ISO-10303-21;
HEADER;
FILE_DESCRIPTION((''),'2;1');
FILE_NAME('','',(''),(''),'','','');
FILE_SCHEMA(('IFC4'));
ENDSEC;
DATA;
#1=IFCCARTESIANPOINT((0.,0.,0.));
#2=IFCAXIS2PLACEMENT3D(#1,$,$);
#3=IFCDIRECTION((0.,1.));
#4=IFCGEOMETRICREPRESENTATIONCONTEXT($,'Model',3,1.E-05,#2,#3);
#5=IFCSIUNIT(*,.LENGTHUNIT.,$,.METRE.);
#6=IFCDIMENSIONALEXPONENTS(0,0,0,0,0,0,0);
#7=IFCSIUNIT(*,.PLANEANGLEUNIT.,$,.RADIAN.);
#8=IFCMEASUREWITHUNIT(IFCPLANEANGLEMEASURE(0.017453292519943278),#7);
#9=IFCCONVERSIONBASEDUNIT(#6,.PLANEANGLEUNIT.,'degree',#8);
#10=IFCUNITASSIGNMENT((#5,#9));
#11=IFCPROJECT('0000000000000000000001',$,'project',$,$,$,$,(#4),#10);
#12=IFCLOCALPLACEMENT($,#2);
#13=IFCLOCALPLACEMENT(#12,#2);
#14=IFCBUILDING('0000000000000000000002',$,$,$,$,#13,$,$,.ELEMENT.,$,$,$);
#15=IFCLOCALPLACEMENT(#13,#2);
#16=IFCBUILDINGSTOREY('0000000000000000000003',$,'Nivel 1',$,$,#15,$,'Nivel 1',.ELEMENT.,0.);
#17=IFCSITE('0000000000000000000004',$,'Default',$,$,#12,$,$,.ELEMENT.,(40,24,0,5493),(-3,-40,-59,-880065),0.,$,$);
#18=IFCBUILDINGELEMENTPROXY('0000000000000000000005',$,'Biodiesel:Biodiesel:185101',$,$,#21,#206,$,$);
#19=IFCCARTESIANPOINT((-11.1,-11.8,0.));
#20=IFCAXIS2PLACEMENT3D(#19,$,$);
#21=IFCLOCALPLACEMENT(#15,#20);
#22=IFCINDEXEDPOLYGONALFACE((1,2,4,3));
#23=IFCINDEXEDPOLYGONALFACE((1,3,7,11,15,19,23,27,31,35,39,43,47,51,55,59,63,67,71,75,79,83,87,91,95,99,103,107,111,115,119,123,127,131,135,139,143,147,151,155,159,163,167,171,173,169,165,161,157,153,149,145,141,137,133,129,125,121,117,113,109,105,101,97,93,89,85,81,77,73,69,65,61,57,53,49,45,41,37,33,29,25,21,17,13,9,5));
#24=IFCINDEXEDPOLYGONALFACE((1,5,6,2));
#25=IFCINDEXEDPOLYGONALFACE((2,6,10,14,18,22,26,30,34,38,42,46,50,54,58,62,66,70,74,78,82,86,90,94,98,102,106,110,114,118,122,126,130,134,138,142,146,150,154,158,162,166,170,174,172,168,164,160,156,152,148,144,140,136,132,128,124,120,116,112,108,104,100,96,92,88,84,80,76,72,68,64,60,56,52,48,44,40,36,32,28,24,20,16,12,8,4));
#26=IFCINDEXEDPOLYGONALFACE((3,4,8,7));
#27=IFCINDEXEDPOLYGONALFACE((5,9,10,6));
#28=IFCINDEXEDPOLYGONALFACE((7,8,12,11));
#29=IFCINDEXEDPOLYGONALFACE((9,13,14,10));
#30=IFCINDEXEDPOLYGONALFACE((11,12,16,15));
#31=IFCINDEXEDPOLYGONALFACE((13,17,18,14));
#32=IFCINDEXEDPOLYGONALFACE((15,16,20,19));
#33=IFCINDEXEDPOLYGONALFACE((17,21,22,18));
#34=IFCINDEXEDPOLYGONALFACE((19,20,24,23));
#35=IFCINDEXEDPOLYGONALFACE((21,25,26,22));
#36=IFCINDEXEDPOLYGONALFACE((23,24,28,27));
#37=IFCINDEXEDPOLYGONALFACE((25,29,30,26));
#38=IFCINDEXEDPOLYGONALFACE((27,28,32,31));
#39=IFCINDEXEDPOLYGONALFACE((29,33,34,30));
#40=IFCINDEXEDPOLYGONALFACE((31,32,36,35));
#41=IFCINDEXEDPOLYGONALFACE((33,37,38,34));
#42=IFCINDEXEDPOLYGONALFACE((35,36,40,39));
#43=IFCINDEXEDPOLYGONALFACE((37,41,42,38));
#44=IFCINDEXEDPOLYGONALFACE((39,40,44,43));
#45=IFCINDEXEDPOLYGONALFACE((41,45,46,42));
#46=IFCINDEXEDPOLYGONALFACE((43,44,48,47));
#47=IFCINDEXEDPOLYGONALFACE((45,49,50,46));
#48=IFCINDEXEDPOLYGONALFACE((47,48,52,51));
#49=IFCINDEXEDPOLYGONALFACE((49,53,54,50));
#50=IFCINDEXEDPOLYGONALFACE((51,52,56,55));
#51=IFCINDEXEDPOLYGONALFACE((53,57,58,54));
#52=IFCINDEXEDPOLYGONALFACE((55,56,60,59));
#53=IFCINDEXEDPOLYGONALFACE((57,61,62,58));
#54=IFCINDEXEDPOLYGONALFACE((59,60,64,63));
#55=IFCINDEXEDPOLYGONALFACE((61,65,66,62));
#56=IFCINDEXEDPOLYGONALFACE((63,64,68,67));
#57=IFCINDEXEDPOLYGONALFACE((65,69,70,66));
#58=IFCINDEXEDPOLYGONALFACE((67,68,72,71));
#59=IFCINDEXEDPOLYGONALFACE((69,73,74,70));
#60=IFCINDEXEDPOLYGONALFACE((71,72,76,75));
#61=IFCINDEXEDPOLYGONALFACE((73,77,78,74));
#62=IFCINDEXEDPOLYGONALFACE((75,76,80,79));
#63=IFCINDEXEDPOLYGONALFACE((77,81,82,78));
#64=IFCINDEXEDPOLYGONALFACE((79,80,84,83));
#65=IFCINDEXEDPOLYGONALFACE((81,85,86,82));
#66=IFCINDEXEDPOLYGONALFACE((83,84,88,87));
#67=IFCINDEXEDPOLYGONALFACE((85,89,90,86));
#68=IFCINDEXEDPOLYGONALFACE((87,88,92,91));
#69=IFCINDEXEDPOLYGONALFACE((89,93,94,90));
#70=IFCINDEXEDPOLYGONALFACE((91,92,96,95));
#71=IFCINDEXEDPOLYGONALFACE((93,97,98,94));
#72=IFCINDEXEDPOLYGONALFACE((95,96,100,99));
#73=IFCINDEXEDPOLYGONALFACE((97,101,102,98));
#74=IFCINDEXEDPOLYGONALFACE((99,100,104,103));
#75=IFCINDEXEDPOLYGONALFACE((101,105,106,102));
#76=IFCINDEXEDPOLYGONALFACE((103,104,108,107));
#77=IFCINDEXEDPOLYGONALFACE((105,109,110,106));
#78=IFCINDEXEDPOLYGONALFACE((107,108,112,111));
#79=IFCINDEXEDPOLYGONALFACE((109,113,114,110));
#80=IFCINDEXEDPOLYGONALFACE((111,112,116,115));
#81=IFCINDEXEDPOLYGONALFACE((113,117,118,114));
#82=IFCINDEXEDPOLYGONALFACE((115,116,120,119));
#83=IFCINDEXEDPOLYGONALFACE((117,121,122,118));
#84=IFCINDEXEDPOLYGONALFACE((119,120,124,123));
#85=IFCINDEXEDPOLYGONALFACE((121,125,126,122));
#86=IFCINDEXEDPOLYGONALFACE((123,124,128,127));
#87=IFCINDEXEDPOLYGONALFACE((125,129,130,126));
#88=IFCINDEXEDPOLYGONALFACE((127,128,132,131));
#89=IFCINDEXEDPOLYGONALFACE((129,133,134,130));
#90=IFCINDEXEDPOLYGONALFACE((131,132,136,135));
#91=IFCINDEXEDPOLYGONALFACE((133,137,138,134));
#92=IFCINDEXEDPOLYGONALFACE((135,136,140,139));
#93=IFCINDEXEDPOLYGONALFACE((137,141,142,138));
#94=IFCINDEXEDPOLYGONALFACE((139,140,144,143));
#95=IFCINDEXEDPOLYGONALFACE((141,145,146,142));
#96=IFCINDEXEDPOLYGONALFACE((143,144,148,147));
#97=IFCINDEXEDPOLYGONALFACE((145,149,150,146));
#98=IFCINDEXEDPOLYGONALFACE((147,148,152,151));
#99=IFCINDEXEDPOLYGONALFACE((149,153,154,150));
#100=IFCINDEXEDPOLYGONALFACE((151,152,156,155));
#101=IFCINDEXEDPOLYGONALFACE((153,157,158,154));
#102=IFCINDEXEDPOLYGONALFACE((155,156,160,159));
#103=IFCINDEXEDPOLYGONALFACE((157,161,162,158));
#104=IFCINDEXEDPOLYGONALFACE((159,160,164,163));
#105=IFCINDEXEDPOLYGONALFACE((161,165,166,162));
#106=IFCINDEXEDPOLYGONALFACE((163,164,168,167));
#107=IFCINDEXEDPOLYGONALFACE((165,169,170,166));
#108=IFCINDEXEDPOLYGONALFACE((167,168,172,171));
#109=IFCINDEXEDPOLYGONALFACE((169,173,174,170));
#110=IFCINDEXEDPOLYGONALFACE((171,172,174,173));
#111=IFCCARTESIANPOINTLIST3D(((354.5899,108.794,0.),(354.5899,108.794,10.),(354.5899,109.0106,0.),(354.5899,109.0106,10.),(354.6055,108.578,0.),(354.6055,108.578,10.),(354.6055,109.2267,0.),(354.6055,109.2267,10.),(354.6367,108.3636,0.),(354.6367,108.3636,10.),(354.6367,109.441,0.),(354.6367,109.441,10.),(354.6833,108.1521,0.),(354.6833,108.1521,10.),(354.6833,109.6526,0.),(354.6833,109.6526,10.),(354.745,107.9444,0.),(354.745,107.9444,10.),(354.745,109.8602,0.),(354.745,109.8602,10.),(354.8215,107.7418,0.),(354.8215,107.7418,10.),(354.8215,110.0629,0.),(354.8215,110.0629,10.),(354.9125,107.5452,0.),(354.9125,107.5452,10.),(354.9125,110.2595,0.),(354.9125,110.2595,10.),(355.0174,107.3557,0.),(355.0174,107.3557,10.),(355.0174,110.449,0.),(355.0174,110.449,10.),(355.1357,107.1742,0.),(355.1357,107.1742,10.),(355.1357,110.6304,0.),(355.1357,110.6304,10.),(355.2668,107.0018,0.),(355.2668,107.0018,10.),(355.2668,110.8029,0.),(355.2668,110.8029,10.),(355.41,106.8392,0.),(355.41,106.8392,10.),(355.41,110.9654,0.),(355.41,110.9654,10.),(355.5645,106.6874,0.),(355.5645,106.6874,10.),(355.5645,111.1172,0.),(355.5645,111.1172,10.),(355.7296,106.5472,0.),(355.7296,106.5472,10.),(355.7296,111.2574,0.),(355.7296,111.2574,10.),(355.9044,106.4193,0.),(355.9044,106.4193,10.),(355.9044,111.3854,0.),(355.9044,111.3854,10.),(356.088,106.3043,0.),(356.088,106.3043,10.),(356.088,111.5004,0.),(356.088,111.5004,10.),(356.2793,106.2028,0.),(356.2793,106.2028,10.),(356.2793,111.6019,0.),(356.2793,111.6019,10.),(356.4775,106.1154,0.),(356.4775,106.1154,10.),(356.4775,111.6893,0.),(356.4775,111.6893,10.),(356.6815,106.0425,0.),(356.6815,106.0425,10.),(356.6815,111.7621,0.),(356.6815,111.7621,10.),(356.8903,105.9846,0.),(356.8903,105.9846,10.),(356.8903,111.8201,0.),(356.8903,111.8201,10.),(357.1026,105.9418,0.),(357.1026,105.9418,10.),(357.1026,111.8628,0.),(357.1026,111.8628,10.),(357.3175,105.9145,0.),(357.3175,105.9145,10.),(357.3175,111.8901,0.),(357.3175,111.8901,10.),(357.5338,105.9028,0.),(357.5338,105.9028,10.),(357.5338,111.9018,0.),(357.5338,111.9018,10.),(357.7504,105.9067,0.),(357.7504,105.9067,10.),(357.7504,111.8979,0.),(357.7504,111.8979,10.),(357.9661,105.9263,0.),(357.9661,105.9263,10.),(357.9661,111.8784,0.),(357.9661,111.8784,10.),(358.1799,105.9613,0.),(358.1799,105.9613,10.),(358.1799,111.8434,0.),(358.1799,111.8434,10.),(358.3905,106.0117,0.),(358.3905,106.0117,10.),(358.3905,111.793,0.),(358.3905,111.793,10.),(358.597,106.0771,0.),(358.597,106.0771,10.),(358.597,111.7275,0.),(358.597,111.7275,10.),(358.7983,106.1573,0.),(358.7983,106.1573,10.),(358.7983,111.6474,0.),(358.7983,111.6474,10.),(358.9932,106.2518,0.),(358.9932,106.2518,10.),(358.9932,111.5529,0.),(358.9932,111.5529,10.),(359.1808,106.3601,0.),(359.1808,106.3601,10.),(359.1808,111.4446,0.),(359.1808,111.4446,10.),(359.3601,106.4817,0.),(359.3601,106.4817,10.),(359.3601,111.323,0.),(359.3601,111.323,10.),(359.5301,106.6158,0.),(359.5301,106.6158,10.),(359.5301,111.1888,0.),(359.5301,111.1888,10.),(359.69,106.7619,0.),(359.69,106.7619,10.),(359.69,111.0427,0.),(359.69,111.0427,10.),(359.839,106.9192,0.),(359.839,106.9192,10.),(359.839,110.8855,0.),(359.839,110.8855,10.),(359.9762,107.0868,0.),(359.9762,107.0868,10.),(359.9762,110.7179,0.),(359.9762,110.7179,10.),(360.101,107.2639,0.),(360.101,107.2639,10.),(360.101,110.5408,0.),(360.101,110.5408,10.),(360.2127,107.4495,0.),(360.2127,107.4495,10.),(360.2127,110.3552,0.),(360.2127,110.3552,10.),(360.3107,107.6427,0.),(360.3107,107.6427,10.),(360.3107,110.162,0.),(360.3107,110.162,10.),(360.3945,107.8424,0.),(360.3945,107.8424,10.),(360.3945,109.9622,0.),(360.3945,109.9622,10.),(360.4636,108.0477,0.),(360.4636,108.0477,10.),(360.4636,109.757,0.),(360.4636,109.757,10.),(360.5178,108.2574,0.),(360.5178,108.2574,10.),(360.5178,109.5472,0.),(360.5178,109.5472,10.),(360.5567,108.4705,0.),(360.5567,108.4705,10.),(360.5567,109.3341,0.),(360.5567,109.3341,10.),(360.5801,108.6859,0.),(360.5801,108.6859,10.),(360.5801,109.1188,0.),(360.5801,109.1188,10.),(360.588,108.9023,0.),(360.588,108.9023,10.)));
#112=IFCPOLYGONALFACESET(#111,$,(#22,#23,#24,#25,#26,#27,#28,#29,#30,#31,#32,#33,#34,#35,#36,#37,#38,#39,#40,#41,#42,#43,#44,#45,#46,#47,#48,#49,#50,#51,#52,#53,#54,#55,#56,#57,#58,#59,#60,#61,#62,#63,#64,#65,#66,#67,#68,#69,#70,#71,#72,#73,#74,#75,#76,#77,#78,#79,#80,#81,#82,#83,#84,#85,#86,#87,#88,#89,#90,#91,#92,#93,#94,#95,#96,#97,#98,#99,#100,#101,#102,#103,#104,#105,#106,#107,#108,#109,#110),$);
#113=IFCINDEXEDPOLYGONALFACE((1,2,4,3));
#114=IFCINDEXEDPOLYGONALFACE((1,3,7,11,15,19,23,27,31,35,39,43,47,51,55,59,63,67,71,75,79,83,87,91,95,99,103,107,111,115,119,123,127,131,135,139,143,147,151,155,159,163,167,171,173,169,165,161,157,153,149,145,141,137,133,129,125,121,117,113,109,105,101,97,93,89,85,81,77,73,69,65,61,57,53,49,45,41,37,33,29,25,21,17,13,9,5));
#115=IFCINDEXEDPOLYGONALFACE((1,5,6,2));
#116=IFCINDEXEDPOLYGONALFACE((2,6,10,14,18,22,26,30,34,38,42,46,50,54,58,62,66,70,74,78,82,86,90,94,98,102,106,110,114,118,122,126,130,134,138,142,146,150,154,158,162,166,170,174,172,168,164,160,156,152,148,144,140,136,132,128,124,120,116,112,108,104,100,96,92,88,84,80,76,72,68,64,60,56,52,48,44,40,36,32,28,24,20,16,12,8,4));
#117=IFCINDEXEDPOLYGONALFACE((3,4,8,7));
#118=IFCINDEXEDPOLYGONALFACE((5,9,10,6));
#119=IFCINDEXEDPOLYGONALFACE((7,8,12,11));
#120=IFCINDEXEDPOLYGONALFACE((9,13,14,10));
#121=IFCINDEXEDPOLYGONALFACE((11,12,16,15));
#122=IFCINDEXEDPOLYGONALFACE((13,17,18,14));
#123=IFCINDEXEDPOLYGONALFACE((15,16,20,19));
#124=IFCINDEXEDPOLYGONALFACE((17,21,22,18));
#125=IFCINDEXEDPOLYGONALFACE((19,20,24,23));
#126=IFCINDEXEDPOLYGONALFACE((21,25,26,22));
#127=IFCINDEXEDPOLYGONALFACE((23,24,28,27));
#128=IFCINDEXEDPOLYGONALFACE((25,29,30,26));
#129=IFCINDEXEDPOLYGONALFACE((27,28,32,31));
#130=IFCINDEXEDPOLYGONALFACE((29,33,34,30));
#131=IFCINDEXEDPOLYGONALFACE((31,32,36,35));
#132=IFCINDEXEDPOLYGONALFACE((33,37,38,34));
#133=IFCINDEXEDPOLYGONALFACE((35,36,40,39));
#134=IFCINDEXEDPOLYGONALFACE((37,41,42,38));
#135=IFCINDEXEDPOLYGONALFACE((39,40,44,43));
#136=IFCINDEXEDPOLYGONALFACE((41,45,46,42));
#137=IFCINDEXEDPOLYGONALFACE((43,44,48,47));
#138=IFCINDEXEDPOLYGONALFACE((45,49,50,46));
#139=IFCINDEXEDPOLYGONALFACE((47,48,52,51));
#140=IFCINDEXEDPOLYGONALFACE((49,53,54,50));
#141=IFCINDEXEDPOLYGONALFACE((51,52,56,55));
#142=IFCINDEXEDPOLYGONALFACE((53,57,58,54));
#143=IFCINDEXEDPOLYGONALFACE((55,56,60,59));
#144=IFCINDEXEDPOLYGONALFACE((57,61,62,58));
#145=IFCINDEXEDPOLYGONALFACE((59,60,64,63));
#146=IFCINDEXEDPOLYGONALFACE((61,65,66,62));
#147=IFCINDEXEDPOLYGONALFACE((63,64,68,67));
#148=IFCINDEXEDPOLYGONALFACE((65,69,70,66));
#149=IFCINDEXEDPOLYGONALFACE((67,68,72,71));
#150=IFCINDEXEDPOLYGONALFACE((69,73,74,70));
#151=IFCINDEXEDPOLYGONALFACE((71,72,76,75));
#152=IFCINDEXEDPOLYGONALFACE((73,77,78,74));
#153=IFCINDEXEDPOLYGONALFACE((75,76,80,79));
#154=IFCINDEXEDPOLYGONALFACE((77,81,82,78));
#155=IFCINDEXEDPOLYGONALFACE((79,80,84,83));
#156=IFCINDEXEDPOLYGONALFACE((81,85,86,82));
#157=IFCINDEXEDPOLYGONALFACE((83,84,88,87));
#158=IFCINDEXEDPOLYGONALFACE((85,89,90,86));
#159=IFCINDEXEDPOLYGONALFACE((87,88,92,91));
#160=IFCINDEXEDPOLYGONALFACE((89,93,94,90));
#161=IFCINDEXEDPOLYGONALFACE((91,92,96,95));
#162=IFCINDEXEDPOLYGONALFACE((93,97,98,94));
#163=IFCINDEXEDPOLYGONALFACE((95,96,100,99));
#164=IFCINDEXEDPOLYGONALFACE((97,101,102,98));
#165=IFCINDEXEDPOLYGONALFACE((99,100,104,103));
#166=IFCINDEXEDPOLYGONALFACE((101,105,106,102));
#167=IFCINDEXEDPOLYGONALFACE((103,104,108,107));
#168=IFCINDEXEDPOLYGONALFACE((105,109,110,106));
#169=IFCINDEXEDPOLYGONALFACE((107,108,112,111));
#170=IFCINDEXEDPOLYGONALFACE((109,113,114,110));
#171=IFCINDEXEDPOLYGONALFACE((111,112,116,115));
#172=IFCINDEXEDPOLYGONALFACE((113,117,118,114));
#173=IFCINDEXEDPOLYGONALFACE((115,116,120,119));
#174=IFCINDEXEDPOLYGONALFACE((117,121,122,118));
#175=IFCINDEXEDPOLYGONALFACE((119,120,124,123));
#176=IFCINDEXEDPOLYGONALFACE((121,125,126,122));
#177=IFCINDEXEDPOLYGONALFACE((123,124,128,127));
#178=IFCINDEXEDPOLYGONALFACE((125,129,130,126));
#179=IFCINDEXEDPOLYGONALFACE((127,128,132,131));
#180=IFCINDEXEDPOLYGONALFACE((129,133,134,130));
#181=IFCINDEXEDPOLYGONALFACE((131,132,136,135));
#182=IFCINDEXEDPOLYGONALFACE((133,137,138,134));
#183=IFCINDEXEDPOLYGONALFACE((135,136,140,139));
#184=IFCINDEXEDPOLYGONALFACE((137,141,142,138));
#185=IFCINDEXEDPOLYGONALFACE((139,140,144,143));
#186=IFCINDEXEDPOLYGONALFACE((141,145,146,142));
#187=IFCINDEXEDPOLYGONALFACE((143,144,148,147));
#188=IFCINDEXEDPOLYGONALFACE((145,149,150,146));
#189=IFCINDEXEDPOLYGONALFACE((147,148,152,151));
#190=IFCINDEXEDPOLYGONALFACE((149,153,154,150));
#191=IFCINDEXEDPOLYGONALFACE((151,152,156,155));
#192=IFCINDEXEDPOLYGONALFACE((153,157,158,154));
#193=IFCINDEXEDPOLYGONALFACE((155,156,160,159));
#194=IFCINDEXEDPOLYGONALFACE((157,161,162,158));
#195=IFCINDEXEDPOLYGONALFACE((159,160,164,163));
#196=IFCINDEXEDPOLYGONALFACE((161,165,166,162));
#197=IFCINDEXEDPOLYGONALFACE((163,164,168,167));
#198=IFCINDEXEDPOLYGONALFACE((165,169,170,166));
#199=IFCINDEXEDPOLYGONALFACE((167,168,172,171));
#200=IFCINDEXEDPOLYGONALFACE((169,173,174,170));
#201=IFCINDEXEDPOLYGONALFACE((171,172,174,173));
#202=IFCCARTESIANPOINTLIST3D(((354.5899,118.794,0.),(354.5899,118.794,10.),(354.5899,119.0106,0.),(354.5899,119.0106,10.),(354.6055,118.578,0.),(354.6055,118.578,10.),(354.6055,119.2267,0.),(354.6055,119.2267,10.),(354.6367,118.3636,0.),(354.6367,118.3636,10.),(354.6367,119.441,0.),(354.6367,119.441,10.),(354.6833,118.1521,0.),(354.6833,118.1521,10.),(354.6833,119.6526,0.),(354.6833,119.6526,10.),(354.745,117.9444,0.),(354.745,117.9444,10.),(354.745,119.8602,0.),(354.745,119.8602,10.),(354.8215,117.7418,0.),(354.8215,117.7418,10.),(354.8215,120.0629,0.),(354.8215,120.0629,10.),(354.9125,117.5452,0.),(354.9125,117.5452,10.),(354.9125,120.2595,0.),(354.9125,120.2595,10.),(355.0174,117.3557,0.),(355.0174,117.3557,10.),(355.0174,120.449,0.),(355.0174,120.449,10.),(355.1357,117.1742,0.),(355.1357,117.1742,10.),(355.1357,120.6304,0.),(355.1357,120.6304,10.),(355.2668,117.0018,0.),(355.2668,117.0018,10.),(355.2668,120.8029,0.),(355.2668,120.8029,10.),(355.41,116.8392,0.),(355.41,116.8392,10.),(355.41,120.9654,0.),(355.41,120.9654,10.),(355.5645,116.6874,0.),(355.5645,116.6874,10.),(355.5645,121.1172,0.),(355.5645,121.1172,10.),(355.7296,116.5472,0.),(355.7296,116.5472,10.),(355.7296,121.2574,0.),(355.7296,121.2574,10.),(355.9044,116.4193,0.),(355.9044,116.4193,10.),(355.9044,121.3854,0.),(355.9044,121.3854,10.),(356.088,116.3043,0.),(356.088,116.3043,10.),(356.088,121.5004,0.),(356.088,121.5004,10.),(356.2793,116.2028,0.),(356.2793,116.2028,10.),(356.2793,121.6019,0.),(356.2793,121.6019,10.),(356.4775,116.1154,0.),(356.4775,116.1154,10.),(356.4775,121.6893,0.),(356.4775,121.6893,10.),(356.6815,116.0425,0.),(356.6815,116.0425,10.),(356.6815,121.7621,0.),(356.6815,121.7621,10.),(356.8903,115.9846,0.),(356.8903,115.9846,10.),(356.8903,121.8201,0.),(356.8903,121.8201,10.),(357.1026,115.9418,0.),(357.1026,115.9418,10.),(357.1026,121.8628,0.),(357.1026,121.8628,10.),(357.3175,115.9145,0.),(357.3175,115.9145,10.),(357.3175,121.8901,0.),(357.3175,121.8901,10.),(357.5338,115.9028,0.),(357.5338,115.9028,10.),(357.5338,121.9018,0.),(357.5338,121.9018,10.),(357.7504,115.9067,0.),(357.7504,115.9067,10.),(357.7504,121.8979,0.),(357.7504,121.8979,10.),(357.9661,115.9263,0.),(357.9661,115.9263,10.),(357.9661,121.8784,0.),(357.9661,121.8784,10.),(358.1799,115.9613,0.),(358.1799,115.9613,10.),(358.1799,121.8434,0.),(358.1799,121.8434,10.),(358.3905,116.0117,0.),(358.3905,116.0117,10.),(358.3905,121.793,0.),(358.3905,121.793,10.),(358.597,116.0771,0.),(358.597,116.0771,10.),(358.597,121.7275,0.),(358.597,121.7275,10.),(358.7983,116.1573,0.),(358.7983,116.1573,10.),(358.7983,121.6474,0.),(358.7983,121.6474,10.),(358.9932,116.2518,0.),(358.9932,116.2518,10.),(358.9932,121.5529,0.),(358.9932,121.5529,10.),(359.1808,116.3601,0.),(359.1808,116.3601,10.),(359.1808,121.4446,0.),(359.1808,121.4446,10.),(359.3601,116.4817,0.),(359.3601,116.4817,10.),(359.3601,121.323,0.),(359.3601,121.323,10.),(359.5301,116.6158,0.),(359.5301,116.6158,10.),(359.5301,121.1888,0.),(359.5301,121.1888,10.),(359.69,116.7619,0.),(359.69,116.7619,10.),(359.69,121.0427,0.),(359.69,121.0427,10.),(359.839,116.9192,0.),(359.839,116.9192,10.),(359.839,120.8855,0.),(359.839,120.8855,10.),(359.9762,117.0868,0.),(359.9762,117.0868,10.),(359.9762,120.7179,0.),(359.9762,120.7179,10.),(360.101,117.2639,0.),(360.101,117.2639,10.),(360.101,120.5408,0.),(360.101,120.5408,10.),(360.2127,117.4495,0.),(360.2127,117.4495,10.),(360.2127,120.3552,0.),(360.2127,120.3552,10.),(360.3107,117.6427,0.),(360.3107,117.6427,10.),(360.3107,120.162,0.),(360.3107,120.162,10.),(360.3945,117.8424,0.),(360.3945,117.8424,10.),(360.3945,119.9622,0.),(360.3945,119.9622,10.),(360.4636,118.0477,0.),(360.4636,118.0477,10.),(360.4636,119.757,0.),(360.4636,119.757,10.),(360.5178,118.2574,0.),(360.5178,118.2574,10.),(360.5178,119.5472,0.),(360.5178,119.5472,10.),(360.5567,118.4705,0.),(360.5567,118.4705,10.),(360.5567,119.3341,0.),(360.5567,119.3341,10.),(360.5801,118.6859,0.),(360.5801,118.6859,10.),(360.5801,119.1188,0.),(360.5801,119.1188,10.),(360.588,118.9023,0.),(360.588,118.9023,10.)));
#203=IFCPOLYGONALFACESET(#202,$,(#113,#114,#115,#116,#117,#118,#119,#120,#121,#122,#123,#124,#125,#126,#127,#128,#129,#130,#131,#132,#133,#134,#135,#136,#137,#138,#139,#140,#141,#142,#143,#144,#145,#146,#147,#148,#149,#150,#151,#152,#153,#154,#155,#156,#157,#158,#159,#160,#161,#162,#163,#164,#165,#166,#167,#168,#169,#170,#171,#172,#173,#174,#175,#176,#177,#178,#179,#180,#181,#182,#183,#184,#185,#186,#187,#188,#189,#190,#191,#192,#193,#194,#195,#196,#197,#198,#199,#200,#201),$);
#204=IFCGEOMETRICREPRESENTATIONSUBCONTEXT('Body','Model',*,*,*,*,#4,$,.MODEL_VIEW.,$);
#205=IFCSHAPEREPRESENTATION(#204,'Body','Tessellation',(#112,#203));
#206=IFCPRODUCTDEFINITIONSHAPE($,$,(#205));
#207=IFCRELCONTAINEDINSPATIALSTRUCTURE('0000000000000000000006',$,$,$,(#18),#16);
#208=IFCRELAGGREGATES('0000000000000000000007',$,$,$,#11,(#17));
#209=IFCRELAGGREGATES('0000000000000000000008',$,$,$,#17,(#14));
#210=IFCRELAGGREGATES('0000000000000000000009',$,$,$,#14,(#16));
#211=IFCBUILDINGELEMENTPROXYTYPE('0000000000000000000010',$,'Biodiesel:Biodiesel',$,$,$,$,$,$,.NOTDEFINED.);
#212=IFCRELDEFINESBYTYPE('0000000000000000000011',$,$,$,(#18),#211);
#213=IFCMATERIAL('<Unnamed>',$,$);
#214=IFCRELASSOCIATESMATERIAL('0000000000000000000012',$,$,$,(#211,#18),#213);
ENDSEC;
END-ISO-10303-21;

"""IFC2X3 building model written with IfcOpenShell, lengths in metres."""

from ifc_helpers import new_model, entity, si_unit, converted_unit, direction, frame, frame_2d, origin, origin_2d_with_axis, place, context, subcontext, project, spatial, circle, extrude, source, transform, mapped, material, type_object, type_shapes, element, save


model = new_model("IFC2X3")

# Units and contexts
model_context = context("Model", 3, precision=1e-05, world=origin(), true_north=direction((0.0, 1.0)))
body_context = subcontext(model_context, "Body", "Model", "MODEL_VIEW")
ifc_project = project(units=[si_unit("LENGTHUNIT", "METRE"), converted_unit("PLANEANGLEUNIT", "degree", entity("IfcPlaneAngleMeasure", 0.017453292519943278), si_unit("PLANEANGLEUNIT", "RADIAN"), dimensions=[0, 0, 0, 0, 0, 0, 0])], contexts=[model_context])

# Site, building, storey
site_placement = place(None, origin())
site = spatial("IfcSite", under=ifc_project, at=site_placement, Name="Default", CompositionType="ELEMENT", RefLatitude=(40, 24, 0, 5493), RefLongitude=(-3, -40, -59, -880065), RefElevation=0.0)
building_placement = place(site_placement, origin())
building = spatial("IfcBuilding", under=site, at=building_placement, CompositionType="ELEMENT")
storey_placement = place(building_placement, origin())
storey = spatial("IfcBuildingStorey", under=building, at=storey_placement, Name="Nivel 1", LongName="Nivel 1", CompositionType="ELEMENT", Elevation=0.0)

# Building element proxy
ifc_material_1 = material(Name="<Unnamed>")
building_element_proxy_type_1 = type_object("IfcBuildingElementProxyType", Name="Biodiesel:Biodiesel", PredefinedType="NOTDEFINED", material=ifc_material_1)
shared_shape_1 = source(origin(), body_context, "Body", "SweptSolid", [
    extrude(circle(Radius=3.0, at=frame_2d((0.0, 0.0), x_axis=(1.0, 0.0))), frame((357.588, 108.9023, 0.0)), (0.0, 0.0, 1.0), 10.0),
    extrude(circle(Radius=3.0, at=origin_2d_with_axis()), frame((357.588, 118.9023, 0.0)), (0.0, 0.0, 1.0), 10.0),
])
type_shapes(building_element_proxy_type_1, [shared_shape_1])
proxy_1_placement = place(storey_placement, frame((-11.1, -11.8, 0.0)))
element("IfcBuildingElementProxy", 1, at=proxy_1_placement, inside=storey, type_object=building_element_proxy_type_1, material=ifc_material_1, Name="Biodiesel:Biodiesel:185101", context=body_context, shape_type="MappedRepresentation", body=[
    mapped(shared_shape_1, transform((0.0, 0.0, 0.0), scale=1.0)),
])

save(model, "model.ifc")
